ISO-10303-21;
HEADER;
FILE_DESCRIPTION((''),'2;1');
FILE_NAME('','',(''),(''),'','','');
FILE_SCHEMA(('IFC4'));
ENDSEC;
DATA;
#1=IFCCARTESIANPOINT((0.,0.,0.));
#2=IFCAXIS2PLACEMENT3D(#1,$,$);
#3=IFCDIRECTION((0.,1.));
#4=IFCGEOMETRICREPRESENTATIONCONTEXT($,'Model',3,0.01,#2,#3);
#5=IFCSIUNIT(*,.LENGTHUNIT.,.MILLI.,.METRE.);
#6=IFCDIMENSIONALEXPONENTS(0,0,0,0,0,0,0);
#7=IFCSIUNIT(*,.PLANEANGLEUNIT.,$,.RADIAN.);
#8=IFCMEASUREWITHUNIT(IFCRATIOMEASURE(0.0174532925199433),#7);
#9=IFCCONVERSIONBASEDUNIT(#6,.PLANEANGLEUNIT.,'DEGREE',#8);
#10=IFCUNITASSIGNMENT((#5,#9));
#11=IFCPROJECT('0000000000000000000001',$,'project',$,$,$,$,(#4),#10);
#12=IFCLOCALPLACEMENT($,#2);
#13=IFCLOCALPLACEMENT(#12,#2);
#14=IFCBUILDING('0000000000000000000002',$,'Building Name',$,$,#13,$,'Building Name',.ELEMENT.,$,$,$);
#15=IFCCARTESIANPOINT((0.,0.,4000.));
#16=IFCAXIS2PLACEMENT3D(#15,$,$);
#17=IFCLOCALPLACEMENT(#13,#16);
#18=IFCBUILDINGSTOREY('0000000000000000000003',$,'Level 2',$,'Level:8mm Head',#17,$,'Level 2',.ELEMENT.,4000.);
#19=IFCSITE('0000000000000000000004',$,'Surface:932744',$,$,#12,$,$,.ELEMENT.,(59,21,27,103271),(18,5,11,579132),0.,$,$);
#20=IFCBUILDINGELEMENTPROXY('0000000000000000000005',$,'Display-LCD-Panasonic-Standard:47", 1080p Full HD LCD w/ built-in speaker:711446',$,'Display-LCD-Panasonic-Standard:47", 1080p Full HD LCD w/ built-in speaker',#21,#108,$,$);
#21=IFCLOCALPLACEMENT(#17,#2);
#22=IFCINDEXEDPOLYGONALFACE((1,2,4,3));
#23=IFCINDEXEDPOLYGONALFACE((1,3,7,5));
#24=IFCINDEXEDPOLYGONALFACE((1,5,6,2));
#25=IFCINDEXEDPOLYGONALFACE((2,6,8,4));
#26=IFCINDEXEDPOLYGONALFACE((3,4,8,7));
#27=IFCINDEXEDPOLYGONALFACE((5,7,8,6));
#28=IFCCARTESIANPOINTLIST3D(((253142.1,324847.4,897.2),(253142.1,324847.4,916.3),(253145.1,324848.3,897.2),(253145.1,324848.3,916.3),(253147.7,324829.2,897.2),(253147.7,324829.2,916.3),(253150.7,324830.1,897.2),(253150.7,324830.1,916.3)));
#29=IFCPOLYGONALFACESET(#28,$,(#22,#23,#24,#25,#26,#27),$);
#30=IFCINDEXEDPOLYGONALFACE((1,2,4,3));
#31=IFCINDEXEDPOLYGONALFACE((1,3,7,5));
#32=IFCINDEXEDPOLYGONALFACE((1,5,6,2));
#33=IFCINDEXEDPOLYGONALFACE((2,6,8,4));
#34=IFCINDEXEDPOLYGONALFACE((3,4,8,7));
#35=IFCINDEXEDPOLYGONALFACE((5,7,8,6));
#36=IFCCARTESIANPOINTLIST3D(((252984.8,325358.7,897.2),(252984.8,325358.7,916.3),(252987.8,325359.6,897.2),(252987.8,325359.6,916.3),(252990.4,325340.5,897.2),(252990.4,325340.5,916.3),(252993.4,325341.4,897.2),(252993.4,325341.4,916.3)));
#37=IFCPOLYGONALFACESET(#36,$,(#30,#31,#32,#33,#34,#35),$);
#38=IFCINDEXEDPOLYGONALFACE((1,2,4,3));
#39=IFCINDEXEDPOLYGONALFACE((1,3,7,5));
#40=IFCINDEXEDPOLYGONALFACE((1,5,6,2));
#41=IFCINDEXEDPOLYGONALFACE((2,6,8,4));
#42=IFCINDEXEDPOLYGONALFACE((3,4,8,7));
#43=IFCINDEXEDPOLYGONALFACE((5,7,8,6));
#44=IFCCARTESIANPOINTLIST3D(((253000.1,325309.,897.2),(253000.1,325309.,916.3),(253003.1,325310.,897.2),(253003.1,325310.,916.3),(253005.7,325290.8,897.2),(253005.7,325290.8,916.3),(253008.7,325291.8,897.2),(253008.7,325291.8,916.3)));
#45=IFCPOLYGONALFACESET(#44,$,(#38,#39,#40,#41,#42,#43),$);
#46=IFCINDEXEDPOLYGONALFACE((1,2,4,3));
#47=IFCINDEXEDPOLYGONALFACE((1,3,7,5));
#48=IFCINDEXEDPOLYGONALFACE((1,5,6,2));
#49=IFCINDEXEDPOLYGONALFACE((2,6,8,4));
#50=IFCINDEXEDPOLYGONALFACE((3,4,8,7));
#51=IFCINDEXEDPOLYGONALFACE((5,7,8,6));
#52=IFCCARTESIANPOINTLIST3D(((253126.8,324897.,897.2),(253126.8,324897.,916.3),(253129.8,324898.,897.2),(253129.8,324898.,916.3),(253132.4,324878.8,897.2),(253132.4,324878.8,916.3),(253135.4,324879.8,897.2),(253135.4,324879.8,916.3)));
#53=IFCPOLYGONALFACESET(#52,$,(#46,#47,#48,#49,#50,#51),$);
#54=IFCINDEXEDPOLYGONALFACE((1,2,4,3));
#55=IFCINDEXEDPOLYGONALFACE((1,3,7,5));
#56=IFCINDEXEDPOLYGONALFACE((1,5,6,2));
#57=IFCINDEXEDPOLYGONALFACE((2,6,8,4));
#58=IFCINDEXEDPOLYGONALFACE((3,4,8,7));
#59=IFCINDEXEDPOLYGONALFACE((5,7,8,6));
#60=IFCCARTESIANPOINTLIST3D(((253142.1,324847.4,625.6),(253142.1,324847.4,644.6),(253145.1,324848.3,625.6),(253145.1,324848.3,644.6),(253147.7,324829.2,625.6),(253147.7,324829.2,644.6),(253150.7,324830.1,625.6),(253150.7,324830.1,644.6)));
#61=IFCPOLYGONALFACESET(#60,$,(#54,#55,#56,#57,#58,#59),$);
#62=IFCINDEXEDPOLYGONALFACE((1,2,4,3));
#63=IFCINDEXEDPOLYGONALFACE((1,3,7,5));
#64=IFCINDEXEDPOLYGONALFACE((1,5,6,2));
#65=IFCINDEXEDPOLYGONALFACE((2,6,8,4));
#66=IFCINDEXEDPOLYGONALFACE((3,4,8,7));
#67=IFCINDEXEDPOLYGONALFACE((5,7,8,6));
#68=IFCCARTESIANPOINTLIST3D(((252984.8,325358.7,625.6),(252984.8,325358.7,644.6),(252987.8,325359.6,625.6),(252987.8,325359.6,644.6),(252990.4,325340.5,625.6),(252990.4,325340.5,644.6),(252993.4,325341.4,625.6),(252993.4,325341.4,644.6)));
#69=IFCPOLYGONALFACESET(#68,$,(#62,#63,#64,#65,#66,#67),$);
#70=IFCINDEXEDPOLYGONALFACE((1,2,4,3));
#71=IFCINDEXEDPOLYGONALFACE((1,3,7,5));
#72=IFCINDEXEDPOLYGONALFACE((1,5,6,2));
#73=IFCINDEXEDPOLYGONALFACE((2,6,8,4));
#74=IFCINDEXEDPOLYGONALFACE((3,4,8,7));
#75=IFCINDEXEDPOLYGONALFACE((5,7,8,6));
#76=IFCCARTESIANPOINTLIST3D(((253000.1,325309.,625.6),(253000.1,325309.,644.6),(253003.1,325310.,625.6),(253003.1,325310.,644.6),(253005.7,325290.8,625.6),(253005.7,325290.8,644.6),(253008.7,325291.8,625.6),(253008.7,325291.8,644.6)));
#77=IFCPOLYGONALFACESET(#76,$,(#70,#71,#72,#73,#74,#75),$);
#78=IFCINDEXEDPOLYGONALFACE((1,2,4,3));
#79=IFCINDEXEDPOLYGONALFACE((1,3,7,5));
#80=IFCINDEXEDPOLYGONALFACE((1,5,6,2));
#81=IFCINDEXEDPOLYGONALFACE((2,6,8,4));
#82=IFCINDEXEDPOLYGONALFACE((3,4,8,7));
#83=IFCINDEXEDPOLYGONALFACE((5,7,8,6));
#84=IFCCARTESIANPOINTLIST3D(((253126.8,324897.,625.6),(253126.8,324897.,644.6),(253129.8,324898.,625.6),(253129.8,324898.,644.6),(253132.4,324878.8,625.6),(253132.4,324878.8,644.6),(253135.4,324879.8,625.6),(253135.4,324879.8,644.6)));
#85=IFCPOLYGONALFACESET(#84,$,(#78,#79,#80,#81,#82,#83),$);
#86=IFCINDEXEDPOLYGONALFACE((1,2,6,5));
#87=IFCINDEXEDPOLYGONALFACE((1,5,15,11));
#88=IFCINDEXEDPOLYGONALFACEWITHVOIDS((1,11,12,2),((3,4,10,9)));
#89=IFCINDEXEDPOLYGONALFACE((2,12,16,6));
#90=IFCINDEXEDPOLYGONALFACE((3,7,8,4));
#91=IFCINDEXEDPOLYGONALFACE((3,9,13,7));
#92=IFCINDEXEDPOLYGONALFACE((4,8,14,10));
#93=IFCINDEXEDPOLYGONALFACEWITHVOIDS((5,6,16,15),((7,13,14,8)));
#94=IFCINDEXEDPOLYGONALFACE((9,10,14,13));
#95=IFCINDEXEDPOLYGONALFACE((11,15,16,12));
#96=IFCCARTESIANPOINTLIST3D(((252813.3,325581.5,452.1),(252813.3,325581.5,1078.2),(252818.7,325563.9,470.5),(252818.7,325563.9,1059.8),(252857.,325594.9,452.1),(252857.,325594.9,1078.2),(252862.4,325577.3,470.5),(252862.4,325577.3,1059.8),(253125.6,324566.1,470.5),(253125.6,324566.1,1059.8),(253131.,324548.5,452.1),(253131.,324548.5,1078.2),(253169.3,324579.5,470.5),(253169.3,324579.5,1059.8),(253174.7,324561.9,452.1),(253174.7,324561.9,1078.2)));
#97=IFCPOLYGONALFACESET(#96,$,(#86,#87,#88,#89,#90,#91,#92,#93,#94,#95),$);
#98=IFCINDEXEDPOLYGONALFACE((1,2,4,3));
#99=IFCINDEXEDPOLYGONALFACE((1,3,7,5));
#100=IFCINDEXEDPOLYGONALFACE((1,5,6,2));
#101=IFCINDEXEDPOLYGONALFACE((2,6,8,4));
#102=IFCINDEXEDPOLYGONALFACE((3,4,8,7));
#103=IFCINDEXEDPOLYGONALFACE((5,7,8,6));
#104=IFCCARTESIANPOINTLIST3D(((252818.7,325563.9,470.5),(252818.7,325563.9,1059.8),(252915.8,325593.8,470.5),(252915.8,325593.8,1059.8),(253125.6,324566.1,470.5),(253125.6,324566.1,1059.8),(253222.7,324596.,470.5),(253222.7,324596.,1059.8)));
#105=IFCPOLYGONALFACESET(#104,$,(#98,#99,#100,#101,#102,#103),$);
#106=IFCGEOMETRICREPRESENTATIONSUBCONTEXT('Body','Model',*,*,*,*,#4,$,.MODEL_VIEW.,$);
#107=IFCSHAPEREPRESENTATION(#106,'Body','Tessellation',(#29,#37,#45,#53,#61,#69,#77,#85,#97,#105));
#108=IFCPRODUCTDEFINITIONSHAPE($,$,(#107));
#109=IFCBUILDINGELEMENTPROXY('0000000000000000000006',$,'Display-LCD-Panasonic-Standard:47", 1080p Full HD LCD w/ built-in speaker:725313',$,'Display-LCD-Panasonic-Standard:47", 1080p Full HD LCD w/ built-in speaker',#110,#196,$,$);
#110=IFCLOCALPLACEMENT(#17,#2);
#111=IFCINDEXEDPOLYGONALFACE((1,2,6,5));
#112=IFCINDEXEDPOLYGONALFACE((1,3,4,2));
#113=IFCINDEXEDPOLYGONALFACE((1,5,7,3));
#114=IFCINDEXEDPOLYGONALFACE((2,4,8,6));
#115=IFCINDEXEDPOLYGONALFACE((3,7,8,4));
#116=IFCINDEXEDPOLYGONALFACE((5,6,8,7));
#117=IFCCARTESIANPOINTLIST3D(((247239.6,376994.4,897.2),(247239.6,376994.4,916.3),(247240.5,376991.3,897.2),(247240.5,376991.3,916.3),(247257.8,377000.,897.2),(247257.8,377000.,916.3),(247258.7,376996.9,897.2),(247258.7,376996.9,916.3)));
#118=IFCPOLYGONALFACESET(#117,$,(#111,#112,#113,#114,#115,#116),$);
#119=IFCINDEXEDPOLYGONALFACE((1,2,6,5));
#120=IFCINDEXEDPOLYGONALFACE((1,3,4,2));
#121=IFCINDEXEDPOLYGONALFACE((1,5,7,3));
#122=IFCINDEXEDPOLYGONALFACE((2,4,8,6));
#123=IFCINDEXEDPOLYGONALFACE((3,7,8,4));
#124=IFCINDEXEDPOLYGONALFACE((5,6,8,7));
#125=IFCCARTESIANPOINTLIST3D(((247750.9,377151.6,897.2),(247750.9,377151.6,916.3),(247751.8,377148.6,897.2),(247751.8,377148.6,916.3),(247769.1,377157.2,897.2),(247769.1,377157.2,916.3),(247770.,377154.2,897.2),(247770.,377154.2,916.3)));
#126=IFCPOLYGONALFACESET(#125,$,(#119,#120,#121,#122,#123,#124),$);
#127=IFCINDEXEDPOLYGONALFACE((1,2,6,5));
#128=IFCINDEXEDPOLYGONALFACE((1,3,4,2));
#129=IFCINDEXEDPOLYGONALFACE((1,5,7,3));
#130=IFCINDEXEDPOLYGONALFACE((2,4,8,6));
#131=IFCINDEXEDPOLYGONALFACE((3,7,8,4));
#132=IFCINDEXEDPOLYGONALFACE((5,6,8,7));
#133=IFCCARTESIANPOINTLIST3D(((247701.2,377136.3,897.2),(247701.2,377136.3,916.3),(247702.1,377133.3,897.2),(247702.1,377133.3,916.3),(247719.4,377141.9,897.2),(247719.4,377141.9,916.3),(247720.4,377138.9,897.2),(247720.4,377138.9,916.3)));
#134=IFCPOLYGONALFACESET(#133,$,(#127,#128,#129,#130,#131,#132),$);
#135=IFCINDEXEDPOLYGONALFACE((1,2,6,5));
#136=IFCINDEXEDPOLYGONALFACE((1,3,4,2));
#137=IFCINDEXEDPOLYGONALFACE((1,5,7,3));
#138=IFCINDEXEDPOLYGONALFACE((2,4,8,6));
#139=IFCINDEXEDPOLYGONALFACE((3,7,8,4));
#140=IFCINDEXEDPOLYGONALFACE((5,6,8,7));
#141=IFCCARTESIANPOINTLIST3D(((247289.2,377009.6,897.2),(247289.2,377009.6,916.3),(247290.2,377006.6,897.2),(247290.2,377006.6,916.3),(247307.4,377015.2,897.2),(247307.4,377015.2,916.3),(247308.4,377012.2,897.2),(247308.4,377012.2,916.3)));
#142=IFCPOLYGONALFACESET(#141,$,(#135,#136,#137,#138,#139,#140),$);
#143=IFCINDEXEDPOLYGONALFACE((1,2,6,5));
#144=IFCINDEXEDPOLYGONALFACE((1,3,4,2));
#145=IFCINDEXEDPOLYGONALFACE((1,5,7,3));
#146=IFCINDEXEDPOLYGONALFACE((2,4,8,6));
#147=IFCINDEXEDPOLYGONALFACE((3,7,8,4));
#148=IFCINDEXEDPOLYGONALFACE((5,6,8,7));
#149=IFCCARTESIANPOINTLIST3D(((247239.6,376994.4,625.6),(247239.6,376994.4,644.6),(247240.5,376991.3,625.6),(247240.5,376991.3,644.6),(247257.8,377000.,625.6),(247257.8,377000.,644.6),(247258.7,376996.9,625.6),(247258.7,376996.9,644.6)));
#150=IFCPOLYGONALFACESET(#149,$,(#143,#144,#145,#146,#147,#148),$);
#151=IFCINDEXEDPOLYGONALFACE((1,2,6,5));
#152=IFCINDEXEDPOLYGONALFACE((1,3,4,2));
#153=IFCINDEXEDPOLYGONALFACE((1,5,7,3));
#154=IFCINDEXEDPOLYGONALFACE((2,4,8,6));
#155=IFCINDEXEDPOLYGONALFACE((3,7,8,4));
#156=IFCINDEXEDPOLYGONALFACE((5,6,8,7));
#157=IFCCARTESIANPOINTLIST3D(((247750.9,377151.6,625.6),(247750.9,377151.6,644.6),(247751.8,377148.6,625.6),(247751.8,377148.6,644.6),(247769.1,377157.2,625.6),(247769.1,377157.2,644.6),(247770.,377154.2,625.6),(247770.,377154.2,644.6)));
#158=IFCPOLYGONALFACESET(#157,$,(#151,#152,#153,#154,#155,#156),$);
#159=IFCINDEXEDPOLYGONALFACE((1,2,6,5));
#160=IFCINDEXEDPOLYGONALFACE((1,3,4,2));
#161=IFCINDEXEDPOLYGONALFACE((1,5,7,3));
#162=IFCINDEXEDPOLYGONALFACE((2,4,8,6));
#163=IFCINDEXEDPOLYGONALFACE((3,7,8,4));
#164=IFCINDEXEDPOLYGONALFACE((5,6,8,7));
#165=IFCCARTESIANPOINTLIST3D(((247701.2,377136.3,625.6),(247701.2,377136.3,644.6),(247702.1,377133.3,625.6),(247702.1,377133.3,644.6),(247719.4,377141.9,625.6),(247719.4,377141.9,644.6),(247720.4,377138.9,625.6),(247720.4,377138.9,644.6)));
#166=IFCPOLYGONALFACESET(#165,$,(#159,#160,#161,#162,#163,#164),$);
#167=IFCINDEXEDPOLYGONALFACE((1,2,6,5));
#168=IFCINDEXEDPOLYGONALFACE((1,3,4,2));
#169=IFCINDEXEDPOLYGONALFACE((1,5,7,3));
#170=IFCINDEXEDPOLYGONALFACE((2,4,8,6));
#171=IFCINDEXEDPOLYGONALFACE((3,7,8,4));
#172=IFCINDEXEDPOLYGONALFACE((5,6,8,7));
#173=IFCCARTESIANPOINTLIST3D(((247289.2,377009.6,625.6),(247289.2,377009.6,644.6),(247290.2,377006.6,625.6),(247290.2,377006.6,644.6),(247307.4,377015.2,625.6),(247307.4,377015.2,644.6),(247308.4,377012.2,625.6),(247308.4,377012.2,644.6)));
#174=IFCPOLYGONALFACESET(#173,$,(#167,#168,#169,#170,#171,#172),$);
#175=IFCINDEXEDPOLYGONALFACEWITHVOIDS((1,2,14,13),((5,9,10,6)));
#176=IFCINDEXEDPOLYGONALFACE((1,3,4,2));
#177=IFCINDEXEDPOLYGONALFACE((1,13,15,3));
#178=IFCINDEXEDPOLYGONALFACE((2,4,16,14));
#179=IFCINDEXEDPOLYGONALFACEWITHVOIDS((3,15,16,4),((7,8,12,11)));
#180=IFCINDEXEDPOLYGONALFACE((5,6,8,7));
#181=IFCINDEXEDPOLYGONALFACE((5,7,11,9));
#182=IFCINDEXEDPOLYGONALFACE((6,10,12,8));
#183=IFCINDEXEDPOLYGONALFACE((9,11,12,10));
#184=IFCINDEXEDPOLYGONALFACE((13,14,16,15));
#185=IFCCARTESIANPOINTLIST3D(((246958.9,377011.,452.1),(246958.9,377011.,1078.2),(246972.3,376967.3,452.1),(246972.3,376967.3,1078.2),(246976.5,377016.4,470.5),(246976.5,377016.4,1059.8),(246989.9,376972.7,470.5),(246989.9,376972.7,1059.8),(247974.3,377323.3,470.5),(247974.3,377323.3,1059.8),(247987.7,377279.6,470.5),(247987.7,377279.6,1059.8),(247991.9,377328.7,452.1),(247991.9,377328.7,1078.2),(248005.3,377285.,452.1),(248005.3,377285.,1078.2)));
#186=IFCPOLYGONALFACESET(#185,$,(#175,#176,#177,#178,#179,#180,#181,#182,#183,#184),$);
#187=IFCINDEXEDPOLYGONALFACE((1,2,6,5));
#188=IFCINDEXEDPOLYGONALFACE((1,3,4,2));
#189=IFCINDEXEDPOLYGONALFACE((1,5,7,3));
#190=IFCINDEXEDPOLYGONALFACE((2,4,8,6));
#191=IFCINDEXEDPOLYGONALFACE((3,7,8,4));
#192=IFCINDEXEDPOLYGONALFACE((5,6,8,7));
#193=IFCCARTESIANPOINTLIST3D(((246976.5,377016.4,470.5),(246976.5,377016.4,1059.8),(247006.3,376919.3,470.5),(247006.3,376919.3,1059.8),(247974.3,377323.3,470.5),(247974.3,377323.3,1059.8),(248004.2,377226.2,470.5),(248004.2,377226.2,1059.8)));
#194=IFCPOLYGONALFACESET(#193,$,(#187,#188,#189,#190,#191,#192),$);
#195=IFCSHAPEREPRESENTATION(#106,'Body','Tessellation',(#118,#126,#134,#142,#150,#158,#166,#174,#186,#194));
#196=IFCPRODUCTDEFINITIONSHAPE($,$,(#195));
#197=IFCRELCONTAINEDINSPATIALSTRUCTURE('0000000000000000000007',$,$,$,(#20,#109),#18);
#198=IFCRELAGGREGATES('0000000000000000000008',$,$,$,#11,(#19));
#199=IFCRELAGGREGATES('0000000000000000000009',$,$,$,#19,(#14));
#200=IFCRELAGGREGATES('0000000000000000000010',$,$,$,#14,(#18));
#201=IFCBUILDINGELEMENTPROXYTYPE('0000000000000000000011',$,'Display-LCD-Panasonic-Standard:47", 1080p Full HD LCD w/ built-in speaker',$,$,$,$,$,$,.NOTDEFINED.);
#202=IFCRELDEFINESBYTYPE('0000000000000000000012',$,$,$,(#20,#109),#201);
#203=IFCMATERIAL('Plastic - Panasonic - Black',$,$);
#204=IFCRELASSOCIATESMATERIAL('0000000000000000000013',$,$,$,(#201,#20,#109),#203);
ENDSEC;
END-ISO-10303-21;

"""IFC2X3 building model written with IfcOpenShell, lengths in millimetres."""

from ifc_helpers import new_model, entity, si_unit, converted_unit, direction, frame, frame_2d, origin, origin_2d_with_axis, place, context, subcontext, project, spatial, polyline, rectangle, outline, extrude, source, transform, mapped, material, type_object, type_shapes, element, save


model = new_model("IFC2X3")

# Units and contexts
model_context = context("Model", 3, precision=0.01, world=origin(), true_north=direction((0.0, 1.0)))
body_context = subcontext(model_context, "Body", "Model", "MODEL_VIEW")
ifc_project = project(units=[si_unit("LENGTHUNIT", "METRE", prefix="MILLI"), converted_unit("PLANEANGLEUNIT", "DEGREE", entity("IfcRatioMeasure", 0.0174532925199433), si_unit("PLANEANGLEUNIT", "RADIAN"), dimensions=[0, 0, 0, 0, 0, 0, 0])], contexts=[model_context])

# Site, building, storey
site_placement = place(None, origin())
site = spatial("IfcSite", under=ifc_project, at=site_placement, Name="Surface:932744", CompositionType="ELEMENT", RefLatitude=(59, 21, 27, 103271), RefLongitude=(18, 5, 11, 579132), RefElevation=0.0)
building_placement = place(site_placement, origin())
building = spatial("IfcBuilding", under=site, at=building_placement, Name="Building Name", LongName="Building Name", CompositionType="ELEMENT")
storey_placement = place(building_placement, frame((0.0, 0.0, 4000.0)))
storey = spatial("IfcBuildingStorey", under=building, at=storey_placement, Name="Level 2", ObjectType="Level:8mm Head", LongName="Level 2", CompositionType="ELEMENT", Elevation=4000.0)

# Building element proxies
ifc_material = material(Name="Plastic - Panasonic - Black")
building_element_proxy_type = type_object("IfcBuildingElementProxyType", Name="Display-LCD-Panasonic-Standard:47\", 1080p Full HD LCD w/ built-in speaker", PredefinedType="NOTDEFINED", material=ifc_material)
shared_shape = source(origin(), body_context, "Body", "SweptSolid", [
    extrude(rectangle(XDim=19.0, YDim=19.1, at=origin_2d_with_axis()), frame((267.5, 187.5, 0.0), z_axis=(0.0, 0.0, 1.0), x_axis=(0.0, 1.0, 0.0)), (0.0, 0.0, 1.0), 3.2),
    extrude(rectangle(XDim=19.0, YDim=19.1, at=origin_2d_with_axis()), frame((-267.5, 187.5, 0.0), z_axis=(0.0, 0.0, 1.0), x_axis=(0.0, 1.0, 0.0)), (0.0, 0.0, 1.0), 3.2),
    extrude(rectangle(XDim=19.0, YDim=19.0, at=origin_2d_with_axis()), frame((-215.5, 187.5, 0.0), z_axis=(0.0, 0.0, 1.0), x_axis=(0.0, 1.0, 0.0)), (0.0, 0.0, 1.0), 3.2),
    extrude(rectangle(XDim=19.0, YDim=19.0, at=frame_2d((0.0, 0.0), x_axis=(1.0, 0.0))), frame((215.5, 187.5, 0.0), z_axis=(0.0, 0.0, 1.0), x_axis=(0.0, 1.0, 0.0)), (0.0, 0.0, 1.0), 3.2),
    extrude(rectangle(XDim=19.0, YDim=19.1, at=frame_2d((0.0, 0.0), x_axis=(1.0, 0.0))), frame((267.5, -84.1, 0.0), z_axis=(0.0, 0.0, 1.0), x_axis=(0.0, 1.0, 0.0)), (0.0, 0.0, 1.0), 3.2),
    extrude(rectangle(XDim=19.0, YDim=19.1, at=frame_2d((0.0, 0.0), x_axis=(1.0, 0.0))), frame((-267.5, -84.1, 0.0), z_axis=(0.0, 0.0, 1.0), x_axis=(0.0, 1.0, 0.0)), (0.0, 0.0, 1.0), 3.2),
    extrude(rectangle(XDim=19.0, YDim=19.0, at=frame_2d((0.0, 0.0), x_axis=(1.0, 0.0))), frame((-215.5, -84.1, 0.0), z_axis=(0.0, 0.0, 1.0), x_axis=(0.0, 1.0, 0.0)), (0.0, 0.0, 1.0), 3.2),
    extrude(rectangle(XDim=19.0, YDim=19.0, at=frame_2d((0.0, 0.0), x_axis=(1.0, 0.0))), frame((215.5, -84.1, 0.0), z_axis=(0.0, 0.0, 1.0), x_axis=(0.0, 1.0, 0.0)), (0.0, 0.0, 1.0), 3.2),
    extrude(outline(polyline([(-313.1, -540.4), (313.1, -540.4), (313.1, 540.4), (-313.1, 540.4), (-313.1, -540.4)]), holes=[polyline([(294.6, -522.0), (-294.6, -522.0), (-294.6, 522.0), (294.6, 522.0), (294.6, -522.0)])]), frame((0.0, 46.0, 55.9), z_axis=(0.0, 0.0, 1.0), x_axis=(0.0, 1.0, 0.0)), (0.0, 0.0, 1.0), 45.7),
    extrude(rectangle(XDim=1043.9, YDim=589.3, at=frame_2d((0.0, 0.0), x_axis=(1.0, 0.0))), frame((0.0, 46.0, 0.0), z_axis=(0.0, 0.0, 1.0), x_axis=(-1.0, 0.0, 0.0)), (0.0, 0.0, 1.0), 101.6),
])
type_shapes(building_element_proxy_type, [shared_shape])
for number, where, z_axis, x_axis, name in (
    (1, (253069.3, 325094.9, 719.2), (-0.955811, -0.29398, 0.0), (0.29398, -0.955811, 0.0), "Display-LCD-Panasonic-Standard:47\", 1080p Full HD LCD w/ built-in speaker:711446"),
    (2, (247505.3, 377072.8, 719.2), (-0.29398, 0.955811, 0.0), (-0.955811, -0.29398, 0.0), "Display-LCD-Panasonic-Standard:47\", 1080p Full HD LCD w/ built-in speaker:725313"),
):
    element("IfcBuildingElementProxy", number, at=place(storey_placement, frame(where, z_axis=z_axis, x_axis=x_axis)), inside=storey, type_object=building_element_proxy_type, material=ifc_material, Name=name, ObjectType="Display-LCD-Panasonic-Standard:47\", 1080p Full HD LCD w/ built-in speaker", context=body_context, shape_type="MappedRepresentation", body=[
        mapped(shared_shape, transform((0.0, 0.0, 0.0), scale=1.0)),
    ])

save(model, "model.ifc")
